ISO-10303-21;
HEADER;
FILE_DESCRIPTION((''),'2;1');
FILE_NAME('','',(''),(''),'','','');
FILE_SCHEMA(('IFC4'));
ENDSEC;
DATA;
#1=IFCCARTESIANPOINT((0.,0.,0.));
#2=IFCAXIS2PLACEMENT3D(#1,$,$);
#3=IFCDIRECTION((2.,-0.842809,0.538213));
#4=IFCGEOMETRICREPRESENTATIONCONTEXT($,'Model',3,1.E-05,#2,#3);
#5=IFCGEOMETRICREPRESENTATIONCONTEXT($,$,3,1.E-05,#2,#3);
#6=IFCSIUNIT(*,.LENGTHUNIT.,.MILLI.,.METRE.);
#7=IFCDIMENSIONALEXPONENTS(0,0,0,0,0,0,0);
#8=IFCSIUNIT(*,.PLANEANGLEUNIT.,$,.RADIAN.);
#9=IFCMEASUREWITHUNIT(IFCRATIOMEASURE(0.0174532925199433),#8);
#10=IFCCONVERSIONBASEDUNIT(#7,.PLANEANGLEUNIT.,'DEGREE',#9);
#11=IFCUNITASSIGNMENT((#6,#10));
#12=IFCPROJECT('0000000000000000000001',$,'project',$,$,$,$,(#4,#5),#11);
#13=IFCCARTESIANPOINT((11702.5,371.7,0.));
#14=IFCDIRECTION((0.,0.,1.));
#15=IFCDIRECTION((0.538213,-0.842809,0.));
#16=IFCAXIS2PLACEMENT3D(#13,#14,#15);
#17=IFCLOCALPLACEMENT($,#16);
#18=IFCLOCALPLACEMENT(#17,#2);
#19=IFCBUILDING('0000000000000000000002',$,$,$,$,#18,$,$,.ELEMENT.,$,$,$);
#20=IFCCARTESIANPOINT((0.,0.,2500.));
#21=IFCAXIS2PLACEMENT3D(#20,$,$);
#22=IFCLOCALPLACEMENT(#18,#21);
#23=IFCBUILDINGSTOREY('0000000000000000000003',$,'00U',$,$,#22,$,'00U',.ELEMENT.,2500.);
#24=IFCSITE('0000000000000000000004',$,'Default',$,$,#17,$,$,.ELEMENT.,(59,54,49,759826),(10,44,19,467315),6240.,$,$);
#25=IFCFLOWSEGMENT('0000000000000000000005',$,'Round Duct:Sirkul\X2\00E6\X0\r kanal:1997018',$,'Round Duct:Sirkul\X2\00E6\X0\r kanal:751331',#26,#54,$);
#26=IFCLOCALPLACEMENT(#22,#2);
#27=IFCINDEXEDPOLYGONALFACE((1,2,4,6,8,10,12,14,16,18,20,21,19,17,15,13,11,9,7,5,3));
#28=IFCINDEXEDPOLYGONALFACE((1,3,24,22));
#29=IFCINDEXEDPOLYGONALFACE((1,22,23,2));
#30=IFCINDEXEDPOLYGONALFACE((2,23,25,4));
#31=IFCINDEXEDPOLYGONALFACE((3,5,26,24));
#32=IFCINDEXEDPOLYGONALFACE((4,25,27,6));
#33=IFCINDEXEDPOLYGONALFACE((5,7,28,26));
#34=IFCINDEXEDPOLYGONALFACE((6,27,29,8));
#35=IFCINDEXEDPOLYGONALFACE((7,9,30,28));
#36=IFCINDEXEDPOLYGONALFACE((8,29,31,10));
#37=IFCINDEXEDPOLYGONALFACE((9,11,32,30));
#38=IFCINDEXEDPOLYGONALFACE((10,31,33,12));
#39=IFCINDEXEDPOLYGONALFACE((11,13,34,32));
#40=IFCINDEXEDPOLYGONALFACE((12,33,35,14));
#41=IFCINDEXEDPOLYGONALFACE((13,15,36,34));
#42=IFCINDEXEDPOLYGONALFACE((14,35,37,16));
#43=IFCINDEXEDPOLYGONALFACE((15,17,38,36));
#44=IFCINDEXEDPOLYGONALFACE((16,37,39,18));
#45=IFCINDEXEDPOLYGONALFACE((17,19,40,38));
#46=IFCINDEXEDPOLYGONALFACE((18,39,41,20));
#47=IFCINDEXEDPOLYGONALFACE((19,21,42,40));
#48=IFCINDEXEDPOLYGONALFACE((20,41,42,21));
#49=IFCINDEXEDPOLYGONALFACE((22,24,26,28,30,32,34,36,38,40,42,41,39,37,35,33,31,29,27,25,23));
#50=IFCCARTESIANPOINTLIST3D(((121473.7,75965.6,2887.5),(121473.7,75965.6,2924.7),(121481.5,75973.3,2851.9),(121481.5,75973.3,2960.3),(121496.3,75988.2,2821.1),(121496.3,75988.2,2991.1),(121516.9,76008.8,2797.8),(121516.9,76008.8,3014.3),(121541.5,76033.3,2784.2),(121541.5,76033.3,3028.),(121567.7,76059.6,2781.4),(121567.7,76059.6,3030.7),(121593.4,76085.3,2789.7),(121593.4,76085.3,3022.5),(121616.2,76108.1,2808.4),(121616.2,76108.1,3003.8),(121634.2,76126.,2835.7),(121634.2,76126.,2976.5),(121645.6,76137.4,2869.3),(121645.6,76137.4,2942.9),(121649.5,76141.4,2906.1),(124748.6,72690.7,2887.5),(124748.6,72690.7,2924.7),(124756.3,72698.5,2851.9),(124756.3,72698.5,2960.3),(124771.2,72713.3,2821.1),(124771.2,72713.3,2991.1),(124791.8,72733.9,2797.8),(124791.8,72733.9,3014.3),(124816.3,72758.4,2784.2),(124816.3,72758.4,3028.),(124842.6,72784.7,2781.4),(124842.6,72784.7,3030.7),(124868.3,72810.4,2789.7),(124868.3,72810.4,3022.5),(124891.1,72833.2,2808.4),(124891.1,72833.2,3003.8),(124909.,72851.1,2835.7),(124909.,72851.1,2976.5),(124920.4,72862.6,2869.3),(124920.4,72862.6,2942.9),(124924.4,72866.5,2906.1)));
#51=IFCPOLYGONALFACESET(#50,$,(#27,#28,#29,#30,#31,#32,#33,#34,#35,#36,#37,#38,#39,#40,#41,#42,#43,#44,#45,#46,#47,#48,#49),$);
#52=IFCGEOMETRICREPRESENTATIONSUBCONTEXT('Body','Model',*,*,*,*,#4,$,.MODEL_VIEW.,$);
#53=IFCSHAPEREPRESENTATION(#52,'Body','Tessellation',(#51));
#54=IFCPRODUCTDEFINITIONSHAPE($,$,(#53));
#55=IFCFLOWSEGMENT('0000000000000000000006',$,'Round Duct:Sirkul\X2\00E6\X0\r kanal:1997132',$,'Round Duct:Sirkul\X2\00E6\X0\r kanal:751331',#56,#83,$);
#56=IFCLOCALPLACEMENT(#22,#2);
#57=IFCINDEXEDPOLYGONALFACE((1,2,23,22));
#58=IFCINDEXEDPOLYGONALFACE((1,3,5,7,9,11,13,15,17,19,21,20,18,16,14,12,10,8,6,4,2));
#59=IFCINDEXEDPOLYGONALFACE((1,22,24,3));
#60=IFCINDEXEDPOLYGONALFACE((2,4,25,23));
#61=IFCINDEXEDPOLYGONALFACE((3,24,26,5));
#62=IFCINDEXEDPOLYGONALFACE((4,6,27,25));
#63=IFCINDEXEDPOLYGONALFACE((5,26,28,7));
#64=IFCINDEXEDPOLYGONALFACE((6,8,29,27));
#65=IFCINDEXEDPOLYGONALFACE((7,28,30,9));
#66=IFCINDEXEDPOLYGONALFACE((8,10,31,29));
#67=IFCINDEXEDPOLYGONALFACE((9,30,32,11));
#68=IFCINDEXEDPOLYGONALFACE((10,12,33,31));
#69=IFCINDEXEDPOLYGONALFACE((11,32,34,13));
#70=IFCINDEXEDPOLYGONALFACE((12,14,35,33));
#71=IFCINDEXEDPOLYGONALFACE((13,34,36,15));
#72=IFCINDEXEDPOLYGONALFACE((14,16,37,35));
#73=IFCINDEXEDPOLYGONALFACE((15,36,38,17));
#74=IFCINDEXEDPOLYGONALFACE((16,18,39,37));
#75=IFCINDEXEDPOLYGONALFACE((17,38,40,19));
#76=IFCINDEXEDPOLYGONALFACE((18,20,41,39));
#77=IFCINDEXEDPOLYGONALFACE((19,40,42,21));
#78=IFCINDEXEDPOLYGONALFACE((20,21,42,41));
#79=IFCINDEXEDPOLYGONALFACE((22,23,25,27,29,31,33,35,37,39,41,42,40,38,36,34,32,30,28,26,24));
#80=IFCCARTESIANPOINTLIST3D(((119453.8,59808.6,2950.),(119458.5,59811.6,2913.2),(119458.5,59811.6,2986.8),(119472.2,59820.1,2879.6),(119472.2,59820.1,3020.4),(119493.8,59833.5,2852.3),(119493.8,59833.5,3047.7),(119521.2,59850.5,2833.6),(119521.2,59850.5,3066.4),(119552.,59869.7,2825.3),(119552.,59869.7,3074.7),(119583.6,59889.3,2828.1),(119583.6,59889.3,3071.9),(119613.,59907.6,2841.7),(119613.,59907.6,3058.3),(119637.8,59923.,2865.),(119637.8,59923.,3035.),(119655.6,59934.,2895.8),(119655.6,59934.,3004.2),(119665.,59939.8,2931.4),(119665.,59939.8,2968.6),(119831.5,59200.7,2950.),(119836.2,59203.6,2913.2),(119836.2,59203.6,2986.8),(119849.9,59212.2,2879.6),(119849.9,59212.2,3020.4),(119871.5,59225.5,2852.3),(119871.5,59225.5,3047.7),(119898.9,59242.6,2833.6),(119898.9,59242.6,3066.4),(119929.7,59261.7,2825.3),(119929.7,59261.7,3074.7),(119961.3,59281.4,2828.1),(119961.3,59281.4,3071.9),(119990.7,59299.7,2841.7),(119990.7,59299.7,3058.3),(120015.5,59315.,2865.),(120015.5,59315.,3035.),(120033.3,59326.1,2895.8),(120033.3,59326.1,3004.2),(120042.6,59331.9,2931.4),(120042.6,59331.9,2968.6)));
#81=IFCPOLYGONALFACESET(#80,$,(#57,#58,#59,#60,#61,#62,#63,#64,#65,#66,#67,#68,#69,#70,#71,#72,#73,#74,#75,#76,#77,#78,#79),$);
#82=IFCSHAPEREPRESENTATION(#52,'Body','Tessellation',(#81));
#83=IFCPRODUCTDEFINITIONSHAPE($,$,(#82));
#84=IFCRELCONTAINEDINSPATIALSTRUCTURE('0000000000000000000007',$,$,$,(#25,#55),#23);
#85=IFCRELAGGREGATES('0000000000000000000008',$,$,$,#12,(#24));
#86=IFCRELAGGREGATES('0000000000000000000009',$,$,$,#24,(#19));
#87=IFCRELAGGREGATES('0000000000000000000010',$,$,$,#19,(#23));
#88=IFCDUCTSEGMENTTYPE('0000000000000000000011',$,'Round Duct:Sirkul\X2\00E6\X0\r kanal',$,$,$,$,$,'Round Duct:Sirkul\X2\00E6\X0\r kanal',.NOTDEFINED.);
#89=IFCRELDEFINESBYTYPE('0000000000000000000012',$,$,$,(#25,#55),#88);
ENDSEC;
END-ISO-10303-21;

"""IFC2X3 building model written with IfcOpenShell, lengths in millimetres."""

from ifc_helpers import new_model, entity, si_unit, converted_unit, direction, frame, origin, origin_2d_with_axis, place, context, subcontext, project, spatial, circle, extrude, type_object, element, save


model = new_model("IFC2X3")

# Units and contexts
model_context = context("Model", 3, precision=1e-05, world=origin(), true_north=direction((2.0, -0.842809, 0.538213)))
context_of_model = context(None, 3, precision=1e-05, world=origin(), true_north=direction((2.0, -0.842809, 0.538213)))
body_context = subcontext(model_context, "Body", "Model", "MODEL_VIEW")
ifc_project = project(units=[si_unit("LENGTHUNIT", "METRE", prefix="MILLI"), converted_unit("PLANEANGLEUNIT", "DEGREE", entity("IfcRatioMeasure", 0.0174532925199433), si_unit("PLANEANGLEUNIT", "RADIAN"), dimensions=[0, 0, 0, 0, 0, 0, 0])], contexts=[model_context, context_of_model])

# Site, building, storey
site_placement = place(None, frame((11702.5, 371.7, 0.0), z_axis=(0.0, 0.0, 1.0), x_axis=(0.538213, -0.842809, 0.0)))
site = spatial("IfcSite", under=ifc_project, at=site_placement, Name="Default", CompositionType="ELEMENT", RefLatitude=(59, 54, 49, 759826), RefLongitude=(10, 44, 19, 467315), RefElevation=6240.0)
building_placement = place(site_placement, origin())
building = spatial("IfcBuilding", under=site, at=building_placement, CompositionType="ELEMENT")
storey_placement = place(building_placement, frame((0.0, 0.0, 2500.0)))
storey = spatial("IfcBuildingStorey", under=building, at=storey_placement, Name="00U", LongName="00U", CompositionType="ELEMENT", Elevation=2500.0)

# Flow segments
duct_segment_type_1 = type_object("IfcDuctSegmentType", Name="Round Duct:Sirkulær kanal", ElementType="Round Duct:Sirkulær kanal", PredefinedType="NOTDEFINED")
flow_segment_1_placement = place(storey_placement, origin())
element("IfcFlowSegment", 1, at=flow_segment_1_placement, inside=storey, type_object=duct_segment_type_1, Name="Round Duct:Sirkulær kanal:1997018", ObjectType="Round Duct:Sirkulær kanal:751331", context=body_context, shape_type="SweptSolid", body=[
    extrude(circle(Radius=125.0, at=origin_2d_with_axis()), frame((124836.0, 72778.1, 2906.1), z_axis=(-0.707107, 0.707107, 0.0), x_axis=(0.707107, 0.707107, 0.0)), (0.0, 0.0, 1.0), 4631.3),
])
flow_segment_2_placement = place(storey_placement, origin())
element("IfcFlowSegment", 2, at=flow_segment_2_placement, inside=storey, type_object=duct_segment_type_1, Name="Round Duct:Sirkulær kanal:1997132", ObjectType="Round Duct:Sirkulær kanal:751331", context=body_context, shape_type="SweptSolid", body=[
    extrude(circle(Radius=125.0, at=origin_2d_with_axis()), frame((119560.0, 59874.6, 2950.0), z_axis=(0.527732, -0.849411, 0.0), x_axis=(-0.849411, -0.527732, 0.0)), (0.0, 0.0, 1.0), 715.7),
])

save(model, "model.ifc")
